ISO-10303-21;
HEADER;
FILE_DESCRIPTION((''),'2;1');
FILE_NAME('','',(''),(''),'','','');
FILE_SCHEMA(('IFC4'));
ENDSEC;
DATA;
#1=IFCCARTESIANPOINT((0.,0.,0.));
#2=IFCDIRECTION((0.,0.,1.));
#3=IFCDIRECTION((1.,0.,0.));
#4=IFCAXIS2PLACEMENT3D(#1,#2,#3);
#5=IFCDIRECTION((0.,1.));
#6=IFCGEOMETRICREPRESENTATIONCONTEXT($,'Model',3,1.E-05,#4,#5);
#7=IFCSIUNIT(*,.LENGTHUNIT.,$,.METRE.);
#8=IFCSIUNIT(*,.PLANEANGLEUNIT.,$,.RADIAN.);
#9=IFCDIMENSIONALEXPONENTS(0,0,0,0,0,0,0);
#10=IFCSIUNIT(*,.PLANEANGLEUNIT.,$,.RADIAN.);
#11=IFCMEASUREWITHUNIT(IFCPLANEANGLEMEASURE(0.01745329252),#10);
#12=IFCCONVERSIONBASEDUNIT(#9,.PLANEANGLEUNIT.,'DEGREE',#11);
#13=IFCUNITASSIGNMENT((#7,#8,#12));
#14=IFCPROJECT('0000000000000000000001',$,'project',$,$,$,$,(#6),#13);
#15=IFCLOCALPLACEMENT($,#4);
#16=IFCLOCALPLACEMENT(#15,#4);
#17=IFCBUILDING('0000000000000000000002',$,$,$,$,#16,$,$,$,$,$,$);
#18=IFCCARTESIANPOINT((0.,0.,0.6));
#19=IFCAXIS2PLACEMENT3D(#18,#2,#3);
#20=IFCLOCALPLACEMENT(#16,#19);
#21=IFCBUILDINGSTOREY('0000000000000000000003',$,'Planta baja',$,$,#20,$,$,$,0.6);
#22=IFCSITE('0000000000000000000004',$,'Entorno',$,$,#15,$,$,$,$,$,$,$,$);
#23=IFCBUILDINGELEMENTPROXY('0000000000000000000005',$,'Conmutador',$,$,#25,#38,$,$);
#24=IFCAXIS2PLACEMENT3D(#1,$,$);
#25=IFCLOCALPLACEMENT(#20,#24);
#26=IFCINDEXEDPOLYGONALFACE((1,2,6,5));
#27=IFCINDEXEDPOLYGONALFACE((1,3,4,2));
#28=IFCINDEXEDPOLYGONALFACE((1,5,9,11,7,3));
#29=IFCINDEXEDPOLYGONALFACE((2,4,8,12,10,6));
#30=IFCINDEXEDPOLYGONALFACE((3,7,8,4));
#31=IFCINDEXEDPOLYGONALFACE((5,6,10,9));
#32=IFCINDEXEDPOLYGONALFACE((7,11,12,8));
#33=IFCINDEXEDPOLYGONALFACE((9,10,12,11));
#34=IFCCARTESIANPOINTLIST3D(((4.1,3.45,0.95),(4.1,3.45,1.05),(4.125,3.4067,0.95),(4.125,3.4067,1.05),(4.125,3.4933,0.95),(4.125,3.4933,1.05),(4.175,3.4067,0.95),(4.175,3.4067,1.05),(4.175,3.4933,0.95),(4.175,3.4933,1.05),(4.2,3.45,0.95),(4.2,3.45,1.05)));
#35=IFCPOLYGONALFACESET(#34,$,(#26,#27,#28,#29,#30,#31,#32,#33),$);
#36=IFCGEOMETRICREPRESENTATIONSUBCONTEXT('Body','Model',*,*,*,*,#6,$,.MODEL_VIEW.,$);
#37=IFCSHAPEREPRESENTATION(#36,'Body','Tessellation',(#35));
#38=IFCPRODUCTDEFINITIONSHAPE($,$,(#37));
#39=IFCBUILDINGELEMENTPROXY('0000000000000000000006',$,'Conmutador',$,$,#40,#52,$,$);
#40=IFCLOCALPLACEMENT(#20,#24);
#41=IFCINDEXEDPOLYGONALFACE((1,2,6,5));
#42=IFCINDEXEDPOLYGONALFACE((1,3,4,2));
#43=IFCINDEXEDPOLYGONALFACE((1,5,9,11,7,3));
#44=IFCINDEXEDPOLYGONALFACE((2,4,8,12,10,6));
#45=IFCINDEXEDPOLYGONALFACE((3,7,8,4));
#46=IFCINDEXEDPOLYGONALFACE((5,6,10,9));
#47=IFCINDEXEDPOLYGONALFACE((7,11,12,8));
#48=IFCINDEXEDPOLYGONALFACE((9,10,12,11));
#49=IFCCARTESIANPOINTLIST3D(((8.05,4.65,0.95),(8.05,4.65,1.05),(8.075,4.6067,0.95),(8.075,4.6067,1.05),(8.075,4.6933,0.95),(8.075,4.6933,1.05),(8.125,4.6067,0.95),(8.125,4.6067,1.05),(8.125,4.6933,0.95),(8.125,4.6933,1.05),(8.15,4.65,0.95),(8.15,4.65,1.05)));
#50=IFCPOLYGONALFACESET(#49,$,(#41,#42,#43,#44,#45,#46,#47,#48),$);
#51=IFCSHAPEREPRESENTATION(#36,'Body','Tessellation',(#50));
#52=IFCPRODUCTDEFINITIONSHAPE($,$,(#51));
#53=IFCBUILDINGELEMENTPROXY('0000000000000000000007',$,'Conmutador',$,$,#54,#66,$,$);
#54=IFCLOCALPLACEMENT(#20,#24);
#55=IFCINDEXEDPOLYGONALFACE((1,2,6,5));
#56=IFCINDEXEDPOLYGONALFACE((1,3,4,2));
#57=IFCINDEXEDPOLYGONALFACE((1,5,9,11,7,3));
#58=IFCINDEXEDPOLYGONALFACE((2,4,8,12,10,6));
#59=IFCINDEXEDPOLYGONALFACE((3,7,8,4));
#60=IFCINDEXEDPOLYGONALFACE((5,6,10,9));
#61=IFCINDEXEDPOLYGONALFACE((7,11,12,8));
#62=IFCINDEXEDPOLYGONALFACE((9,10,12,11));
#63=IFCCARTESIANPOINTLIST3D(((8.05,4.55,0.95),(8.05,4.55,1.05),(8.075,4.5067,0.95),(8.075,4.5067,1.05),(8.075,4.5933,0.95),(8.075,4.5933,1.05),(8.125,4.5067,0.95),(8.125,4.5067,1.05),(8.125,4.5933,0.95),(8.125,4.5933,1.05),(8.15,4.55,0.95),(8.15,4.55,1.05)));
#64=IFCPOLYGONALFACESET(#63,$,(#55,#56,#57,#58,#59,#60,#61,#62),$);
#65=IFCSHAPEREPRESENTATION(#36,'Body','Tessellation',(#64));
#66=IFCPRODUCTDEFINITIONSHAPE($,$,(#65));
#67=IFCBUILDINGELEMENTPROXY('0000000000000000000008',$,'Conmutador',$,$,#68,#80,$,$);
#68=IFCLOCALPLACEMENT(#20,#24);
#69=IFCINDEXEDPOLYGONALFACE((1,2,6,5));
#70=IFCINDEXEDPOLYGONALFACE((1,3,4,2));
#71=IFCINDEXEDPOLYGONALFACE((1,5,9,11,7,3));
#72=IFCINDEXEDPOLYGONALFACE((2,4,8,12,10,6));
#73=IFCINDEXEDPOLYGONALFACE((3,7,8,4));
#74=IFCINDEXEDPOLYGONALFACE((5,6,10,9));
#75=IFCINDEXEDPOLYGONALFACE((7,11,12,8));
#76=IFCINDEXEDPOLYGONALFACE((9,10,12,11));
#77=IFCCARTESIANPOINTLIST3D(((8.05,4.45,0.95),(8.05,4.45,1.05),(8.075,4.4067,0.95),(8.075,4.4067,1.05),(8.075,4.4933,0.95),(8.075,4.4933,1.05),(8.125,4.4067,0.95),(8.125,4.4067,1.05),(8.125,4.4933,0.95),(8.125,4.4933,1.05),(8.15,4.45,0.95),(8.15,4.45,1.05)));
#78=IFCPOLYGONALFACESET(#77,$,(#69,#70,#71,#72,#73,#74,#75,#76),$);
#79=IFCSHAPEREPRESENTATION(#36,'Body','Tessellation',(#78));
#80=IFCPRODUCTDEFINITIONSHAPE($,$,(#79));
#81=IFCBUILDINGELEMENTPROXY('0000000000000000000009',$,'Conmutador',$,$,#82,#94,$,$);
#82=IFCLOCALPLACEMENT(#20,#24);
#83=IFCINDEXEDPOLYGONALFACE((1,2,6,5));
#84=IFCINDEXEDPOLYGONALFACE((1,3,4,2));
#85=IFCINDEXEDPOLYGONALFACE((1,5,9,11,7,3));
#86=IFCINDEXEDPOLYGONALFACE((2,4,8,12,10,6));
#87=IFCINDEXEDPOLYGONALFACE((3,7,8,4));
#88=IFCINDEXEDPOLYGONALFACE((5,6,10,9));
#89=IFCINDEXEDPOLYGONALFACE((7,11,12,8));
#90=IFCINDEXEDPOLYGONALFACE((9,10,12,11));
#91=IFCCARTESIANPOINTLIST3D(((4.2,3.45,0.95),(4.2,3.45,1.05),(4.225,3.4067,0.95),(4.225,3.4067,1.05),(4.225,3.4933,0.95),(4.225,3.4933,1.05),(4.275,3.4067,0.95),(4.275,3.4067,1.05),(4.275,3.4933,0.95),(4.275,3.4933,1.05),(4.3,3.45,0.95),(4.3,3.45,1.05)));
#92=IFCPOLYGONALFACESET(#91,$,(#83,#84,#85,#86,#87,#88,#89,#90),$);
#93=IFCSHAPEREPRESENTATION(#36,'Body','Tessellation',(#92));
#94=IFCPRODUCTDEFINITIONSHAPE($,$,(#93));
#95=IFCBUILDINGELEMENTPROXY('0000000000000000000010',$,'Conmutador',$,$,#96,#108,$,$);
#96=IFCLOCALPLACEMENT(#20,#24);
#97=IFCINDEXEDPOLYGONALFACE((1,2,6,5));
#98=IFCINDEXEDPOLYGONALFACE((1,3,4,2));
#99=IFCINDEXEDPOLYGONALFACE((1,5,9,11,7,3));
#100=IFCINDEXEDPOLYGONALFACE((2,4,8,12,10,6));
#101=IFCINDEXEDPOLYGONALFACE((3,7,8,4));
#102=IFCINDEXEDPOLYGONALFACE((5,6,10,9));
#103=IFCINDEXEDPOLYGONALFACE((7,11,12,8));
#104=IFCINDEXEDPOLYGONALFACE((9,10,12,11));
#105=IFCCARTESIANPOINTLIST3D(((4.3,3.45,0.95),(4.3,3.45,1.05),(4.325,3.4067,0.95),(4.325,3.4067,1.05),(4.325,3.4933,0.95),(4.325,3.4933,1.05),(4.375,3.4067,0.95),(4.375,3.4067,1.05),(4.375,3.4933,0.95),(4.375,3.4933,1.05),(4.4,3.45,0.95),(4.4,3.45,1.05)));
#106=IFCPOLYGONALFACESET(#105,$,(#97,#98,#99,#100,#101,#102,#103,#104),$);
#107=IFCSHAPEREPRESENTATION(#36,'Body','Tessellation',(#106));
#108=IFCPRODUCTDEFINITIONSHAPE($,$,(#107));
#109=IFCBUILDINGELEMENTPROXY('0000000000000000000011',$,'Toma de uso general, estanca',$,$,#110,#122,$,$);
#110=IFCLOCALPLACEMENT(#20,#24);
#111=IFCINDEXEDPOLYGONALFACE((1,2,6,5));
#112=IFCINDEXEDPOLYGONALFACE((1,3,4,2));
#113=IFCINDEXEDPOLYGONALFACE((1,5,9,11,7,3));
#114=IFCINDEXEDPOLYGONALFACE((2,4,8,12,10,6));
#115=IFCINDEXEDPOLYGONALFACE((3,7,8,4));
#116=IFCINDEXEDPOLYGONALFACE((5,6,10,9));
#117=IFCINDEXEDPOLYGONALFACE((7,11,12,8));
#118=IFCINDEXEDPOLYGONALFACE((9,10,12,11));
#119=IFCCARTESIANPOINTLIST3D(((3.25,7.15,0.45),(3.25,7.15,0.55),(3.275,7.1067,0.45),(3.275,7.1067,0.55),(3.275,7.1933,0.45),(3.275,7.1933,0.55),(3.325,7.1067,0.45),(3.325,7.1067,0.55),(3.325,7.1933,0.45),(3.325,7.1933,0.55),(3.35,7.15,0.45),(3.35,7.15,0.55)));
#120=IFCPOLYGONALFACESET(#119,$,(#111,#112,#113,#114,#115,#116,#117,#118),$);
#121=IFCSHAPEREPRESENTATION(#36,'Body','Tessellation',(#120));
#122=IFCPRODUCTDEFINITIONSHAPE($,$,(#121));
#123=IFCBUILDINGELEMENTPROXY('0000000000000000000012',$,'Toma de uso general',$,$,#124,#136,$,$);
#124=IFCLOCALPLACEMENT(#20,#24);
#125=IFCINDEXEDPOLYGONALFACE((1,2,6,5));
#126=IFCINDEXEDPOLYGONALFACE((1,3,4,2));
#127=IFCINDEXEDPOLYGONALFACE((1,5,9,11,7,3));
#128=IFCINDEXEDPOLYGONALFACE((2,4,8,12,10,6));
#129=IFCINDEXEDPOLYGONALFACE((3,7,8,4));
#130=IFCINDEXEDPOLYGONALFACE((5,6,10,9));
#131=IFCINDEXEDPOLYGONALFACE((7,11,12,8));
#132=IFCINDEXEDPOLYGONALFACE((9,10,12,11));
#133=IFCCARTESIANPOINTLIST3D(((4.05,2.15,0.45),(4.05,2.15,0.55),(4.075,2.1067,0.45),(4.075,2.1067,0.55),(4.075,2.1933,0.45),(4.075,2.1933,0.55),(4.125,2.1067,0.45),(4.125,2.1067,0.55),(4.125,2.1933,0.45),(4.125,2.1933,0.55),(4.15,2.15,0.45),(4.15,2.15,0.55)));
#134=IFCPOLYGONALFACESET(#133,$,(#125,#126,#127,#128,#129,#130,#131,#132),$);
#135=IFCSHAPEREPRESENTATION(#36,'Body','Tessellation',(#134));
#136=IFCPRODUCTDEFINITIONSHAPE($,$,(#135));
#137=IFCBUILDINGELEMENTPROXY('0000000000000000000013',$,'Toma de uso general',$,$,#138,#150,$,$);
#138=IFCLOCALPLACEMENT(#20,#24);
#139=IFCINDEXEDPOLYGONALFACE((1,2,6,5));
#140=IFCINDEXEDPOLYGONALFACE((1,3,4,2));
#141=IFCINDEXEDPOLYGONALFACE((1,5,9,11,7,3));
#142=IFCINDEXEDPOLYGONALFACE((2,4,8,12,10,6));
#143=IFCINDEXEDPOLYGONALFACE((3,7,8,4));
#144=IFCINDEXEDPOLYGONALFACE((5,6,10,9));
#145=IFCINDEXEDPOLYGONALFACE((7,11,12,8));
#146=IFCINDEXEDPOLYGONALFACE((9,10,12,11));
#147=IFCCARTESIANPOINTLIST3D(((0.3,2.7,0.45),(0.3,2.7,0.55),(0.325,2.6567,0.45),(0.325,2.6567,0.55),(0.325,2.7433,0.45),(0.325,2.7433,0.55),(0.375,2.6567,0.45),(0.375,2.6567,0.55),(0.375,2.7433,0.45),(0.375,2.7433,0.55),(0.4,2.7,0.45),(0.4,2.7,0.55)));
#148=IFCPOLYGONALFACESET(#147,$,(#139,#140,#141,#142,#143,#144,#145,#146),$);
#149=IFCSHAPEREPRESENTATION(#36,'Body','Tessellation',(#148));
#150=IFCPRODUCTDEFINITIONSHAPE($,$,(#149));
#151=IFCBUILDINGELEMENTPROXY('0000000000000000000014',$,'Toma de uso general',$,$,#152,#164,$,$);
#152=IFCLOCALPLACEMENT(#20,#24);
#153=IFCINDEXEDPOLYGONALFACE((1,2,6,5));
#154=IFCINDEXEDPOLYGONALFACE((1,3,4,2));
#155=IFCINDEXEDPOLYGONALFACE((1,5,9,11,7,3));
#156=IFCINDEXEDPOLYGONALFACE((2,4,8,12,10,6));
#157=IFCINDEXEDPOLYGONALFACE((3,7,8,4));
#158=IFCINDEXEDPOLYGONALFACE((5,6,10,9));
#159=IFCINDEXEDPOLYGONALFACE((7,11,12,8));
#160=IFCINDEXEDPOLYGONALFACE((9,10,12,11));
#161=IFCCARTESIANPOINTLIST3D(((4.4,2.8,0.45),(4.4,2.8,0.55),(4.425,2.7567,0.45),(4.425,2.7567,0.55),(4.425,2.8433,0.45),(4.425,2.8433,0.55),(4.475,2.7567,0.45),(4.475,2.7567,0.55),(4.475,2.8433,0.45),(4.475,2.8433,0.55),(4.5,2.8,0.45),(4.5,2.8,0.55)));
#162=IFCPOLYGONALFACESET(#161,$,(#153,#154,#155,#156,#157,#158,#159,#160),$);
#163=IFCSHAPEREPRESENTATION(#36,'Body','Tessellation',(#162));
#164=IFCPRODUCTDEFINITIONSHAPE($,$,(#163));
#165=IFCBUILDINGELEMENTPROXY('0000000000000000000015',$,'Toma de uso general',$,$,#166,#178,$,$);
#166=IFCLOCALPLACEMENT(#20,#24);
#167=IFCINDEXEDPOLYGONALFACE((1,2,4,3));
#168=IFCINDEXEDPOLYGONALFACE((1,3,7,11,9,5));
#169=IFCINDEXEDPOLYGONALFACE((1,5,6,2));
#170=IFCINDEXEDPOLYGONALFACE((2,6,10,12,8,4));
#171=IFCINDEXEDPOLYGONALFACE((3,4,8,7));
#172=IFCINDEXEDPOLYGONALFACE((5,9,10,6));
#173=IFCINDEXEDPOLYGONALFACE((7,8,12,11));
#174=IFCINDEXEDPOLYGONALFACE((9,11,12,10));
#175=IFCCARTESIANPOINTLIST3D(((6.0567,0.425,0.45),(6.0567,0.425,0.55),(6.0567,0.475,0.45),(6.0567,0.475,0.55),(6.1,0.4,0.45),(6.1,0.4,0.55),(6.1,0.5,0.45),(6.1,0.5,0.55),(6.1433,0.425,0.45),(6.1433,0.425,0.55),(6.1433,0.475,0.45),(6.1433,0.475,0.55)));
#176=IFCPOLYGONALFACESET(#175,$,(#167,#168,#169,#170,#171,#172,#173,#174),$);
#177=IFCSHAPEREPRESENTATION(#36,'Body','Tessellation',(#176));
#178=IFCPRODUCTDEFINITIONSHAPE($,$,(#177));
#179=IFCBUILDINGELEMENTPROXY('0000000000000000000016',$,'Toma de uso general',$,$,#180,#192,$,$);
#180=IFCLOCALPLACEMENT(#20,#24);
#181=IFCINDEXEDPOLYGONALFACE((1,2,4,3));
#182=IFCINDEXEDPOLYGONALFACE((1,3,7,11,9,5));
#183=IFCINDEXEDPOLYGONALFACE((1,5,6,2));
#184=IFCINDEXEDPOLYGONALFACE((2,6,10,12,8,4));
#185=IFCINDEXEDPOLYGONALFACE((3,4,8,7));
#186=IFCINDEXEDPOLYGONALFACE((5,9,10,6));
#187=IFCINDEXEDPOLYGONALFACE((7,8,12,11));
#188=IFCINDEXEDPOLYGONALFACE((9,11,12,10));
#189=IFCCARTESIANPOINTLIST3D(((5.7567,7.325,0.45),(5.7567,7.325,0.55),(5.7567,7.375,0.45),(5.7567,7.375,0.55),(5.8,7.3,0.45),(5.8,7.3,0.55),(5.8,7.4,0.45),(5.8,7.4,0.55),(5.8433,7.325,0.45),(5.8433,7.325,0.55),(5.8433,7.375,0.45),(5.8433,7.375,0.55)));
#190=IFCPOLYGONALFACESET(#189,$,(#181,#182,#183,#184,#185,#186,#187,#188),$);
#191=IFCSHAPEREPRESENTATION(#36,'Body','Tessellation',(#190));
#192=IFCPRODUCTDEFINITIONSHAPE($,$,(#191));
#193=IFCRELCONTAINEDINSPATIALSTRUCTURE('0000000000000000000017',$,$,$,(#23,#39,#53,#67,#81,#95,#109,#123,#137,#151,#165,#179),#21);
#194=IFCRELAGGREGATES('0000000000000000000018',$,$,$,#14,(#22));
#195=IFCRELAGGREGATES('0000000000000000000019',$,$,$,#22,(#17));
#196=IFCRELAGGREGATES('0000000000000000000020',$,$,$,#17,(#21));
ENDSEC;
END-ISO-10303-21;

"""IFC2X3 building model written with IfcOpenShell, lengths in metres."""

from ifc_helpers import new_model, entity, si_unit, converted_unit, direction, frame, origin_with_axes, place, context, subcontext, project, spatial, polyline, outline, extrude, source, transform, mapped, element, save


model = new_model("IFC2X3")

# Units and contexts
model_context = context("Model", 3, precision=1e-05, world=origin_with_axes(), true_north=direction((0.0, 1.0)))
body_context = subcontext(model_context, "Body", "Model", "MODEL_VIEW")
ifc_project = project(units=[si_unit("LENGTHUNIT", "METRE"), si_unit("PLANEANGLEUNIT", "RADIAN"), converted_unit("PLANEANGLEUNIT", "DEGREE", entity("IfcPlaneAngleMeasure", 0.01745329252), si_unit("PLANEANGLEUNIT", "RADIAN"), dimensions=[0, 0, 0, 0, 0, 0, 0])], contexts=[model_context])

# Site, building, storey
site_placement = place(None, origin_with_axes())
site = spatial("IfcSite", under=ifc_project, at=site_placement, Name="Entorno")
building_placement = place(site_placement, origin_with_axes())
building = spatial("IfcBuilding", under=site, at=building_placement)
storey_placement = place(building_placement, frame((0.0, 0.0, 0.6), z_axis=(0.0, 0.0, 1.0), x_axis=(1.0, 0.0, 0.0)))
storey = spatial("IfcBuildingStorey", under=building, at=storey_placement, Name="Planta baja", Elevation=0.6)

# Building element proxies
shared_shape_1 = source(origin_with_axes(), body_context, "Body", "SolidModel", [
    extrude(outline(polyline([(0.05, 0.0), (0.025, 0.0433), (-0.025, 0.0433), (-0.05, 0.0), (-0.025, -0.0433), (0.025, -0.0433), (0.05, 0.0)])), frame((0.0, 0.0, -0.05), z_axis=(0.0, 0.0, 1.0), x_axis=(1.0, 0.0, 0.0)), (0.0, 0.0, 1.0), 0.1),
])
proxy_1_placement = place(storey_placement, frame((0.0, 0.0, -0.6), z_axis=(0.0, 0.0, 1.0), x_axis=(1.0, 0.0, 0.0)))
element("IfcBuildingElementProxy", 1, at=proxy_1_placement, inside=storey, Name="Conmutador", context=body_context, shape_type="Brep", body=[
    mapped(shared_shape_1, transform((4.15, 3.45, 1.6), x_axis=(1.0, 0.0, 0.0), y_axis=(0.0, 1.0, 0.0), z_axis=(0.0, 0.0, 1.0))),
])
proxy_2_placement = place(storey_placement, frame((0.0, 0.0, -0.6), z_axis=(0.0, 0.0, 1.0), x_axis=(1.0, 0.0, 0.0)))
element("IfcBuildingElementProxy", 2, at=proxy_2_placement, inside=storey, Name="Conmutador", context=body_context, shape_type="Brep", body=[
    mapped(shared_shape_1, transform((8.1, 4.65, 1.6), x_axis=(1.0, 0.0, 0.0), y_axis=(0.0, 1.0, 0.0), z_axis=(0.0, 0.0, 1.0))),
])
proxy_3_placement = place(storey_placement, frame((0.0, 0.0, -0.6), z_axis=(0.0, 0.0, 1.0), x_axis=(1.0, 0.0, 0.0)))
element("IfcBuildingElementProxy", 3, at=proxy_3_placement, inside=storey, Name="Conmutador", context=body_context, shape_type="Brep", body=[
    mapped(shared_shape_1, transform((8.1, 4.55, 1.6), x_axis=(1.0, 0.0, 0.0), y_axis=(0.0, 1.0, 0.0), z_axis=(0.0, 0.0, 1.0))),
])
proxy_4_placement = place(storey_placement, frame((0.0, 0.0, -0.6), z_axis=(0.0, 0.0, 1.0), x_axis=(1.0, 0.0, 0.0)))
element("IfcBuildingElementProxy", 4, at=proxy_4_placement, inside=storey, Name="Conmutador", context=body_context, shape_type="Brep", body=[
    mapped(shared_shape_1, transform((8.1, 4.45, 1.6), x_axis=(1.0, 0.0, 0.0), y_axis=(0.0, 1.0, 0.0), z_axis=(0.0, 0.0, 1.0))),
])
proxy_5_placement = place(storey_placement, frame((0.0, 0.0, -0.6), z_axis=(0.0, 0.0, 1.0), x_axis=(1.0, 0.0, 0.0)))
element("IfcBuildingElementProxy", 5, at=proxy_5_placement, inside=storey, Name="Conmutador", context=body_context, shape_type="Brep", body=[
    mapped(shared_shape_1, transform((4.25, 3.45, 1.6), x_axis=(1.0, 0.0, 0.0), y_axis=(0.0, 1.0, 0.0), z_axis=(0.0, 0.0, 1.0))),
])
proxy_6_placement = place(storey_placement, frame((0.0, 0.0, -0.6), z_axis=(0.0, 0.0, 1.0), x_axis=(1.0, 0.0, 0.0)))
element("IfcBuildingElementProxy", 6, at=proxy_6_placement, inside=storey, Name="Conmutador", context=body_context, shape_type="Brep", body=[
    mapped(shared_shape_1, transform((4.35, 3.45, 1.6), x_axis=(1.0, 0.0, 0.0), y_axis=(0.0, 1.0, 0.0), z_axis=(0.0, 0.0, 1.0))),
])
shared_shape_2 = source(origin_with_axes(), body_context, "Body", "SolidModel", [
    extrude(outline(polyline([(0.05, 0.0), (0.025, 0.0433), (-0.025, 0.0433), (-0.05, 0.0), (-0.025, -0.0433), (0.025, -0.0433), (0.05, 0.0)])), frame((0.0, 0.0, -0.05), z_axis=(0.0, 0.0, 1.0), x_axis=(1.0, 0.0, 0.0)), (0.0, 0.0, 1.0), 0.1),
])
proxy_7_placement = place(storey_placement, frame((0.0, 0.0, -0.6), z_axis=(0.0, 0.0, 1.0), x_axis=(1.0, 0.0, 0.0)))
element("IfcBuildingElementProxy", 7, at=proxy_7_placement, inside=storey, Name="Toma de uso general, estanca", context=body_context, shape_type="Brep", body=[
    mapped(shared_shape_2, transform((3.3, 7.15, 1.1), x_axis=(-1.0, 0.0, 0.0), y_axis=(0.0, -1.0, 0.0), z_axis=(0.0, 0.0, 1.0))),
])
shared_shape_3 = source(origin_with_axes(), body_context, "Body", "SolidModel", [
    extrude(outline(polyline([(0.05, 0.0), (0.025, 0.0433), (-0.025, 0.0433), (-0.05, 0.0), (-0.025, -0.0433), (0.025, -0.0433), (0.05, 0.0)])), frame((0.0, 0.0, -0.05), z_axis=(0.0, 0.0, 1.0), x_axis=(1.0, 0.0, 0.0)), (0.0, 0.0, 1.0), 0.1),
])
proxy_8_placement = place(storey_placement, frame((0.0, 0.0, -0.6), z_axis=(0.0, 0.0, 1.0), x_axis=(1.0, 0.0, 0.0)))
element("IfcBuildingElementProxy", 8, at=proxy_8_placement, inside=storey, Name="Toma de uso general", context=body_context, shape_type="Brep", body=[
    mapped(shared_shape_3, transform((4.1, 2.15, 1.1), x_axis=(-1.0, 0.0, 0.0), y_axis=(0.0, -1.0, 0.0), z_axis=(0.0, 0.0, 1.0))),
])
proxy_9_placement = place(storey_placement, frame((0.0, 0.0, -0.6), z_axis=(0.0, 0.0, 1.0), x_axis=(1.0, 0.0, 0.0)))
element("IfcBuildingElementProxy", 9, at=proxy_9_placement, inside=storey, Name="Toma de uso general", context=body_context, shape_type="Brep", body=[
    mapped(shared_shape_3, transform((0.35, 2.7, 1.1), x_axis=(1.0, 0.0, 0.0), y_axis=(0.0, 1.0, 0.0), z_axis=(0.0, 0.0, 1.0))),
])
proxy_10_placement = place(storey_placement, frame((0.0, 0.0, -0.6), z_axis=(0.0, 0.0, 1.0), x_axis=(1.0, 0.0, 0.0)))
element("IfcBuildingElementProxy", 10, at=proxy_10_placement, inside=storey, Name="Toma de uso general", context=body_context, shape_type="Brep", body=[
    mapped(shared_shape_3, transform((4.45, 2.8, 1.1), x_axis=(1.0, 0.0, 0.0), y_axis=(0.0, 1.0, 0.0), z_axis=(0.0, 0.0, 1.0))),
])
proxy_11_placement = place(storey_placement, frame((0.0, 0.0, -0.6), z_axis=(0.0, 0.0, 1.0), x_axis=(1.0, 0.0, 0.0)))
element("IfcBuildingElementProxy", 11, at=proxy_11_placement, inside=storey, Name="Toma de uso general", context=body_context, shape_type="Brep", body=[
    mapped(shared_shape_3, transform((6.1, 0.45, 1.1), x_axis=(0.0, 1.0, 0.0), y_axis=(-1.0, 0.0, 0.0), z_axis=(0.0, 0.0, 1.0))),
])
proxy_12_placement = place(storey_placement, frame((0.0, 0.0, -0.6), z_axis=(0.0, 0.0, 1.0), x_axis=(1.0, 0.0, 0.0)))
element("IfcBuildingElementProxy", 12, at=proxy_12_placement, inside=storey, Name="Toma de uso general", context=body_context, shape_type="Brep", body=[
    mapped(shared_shape_3, transform((5.8, 7.35, 1.1), x_axis=(0.0, -1.0, 0.0), y_axis=(1.0, 0.0, 0.0), z_axis=(0.0, 0.0, 1.0))),
])

save(model, "model.ifc")
